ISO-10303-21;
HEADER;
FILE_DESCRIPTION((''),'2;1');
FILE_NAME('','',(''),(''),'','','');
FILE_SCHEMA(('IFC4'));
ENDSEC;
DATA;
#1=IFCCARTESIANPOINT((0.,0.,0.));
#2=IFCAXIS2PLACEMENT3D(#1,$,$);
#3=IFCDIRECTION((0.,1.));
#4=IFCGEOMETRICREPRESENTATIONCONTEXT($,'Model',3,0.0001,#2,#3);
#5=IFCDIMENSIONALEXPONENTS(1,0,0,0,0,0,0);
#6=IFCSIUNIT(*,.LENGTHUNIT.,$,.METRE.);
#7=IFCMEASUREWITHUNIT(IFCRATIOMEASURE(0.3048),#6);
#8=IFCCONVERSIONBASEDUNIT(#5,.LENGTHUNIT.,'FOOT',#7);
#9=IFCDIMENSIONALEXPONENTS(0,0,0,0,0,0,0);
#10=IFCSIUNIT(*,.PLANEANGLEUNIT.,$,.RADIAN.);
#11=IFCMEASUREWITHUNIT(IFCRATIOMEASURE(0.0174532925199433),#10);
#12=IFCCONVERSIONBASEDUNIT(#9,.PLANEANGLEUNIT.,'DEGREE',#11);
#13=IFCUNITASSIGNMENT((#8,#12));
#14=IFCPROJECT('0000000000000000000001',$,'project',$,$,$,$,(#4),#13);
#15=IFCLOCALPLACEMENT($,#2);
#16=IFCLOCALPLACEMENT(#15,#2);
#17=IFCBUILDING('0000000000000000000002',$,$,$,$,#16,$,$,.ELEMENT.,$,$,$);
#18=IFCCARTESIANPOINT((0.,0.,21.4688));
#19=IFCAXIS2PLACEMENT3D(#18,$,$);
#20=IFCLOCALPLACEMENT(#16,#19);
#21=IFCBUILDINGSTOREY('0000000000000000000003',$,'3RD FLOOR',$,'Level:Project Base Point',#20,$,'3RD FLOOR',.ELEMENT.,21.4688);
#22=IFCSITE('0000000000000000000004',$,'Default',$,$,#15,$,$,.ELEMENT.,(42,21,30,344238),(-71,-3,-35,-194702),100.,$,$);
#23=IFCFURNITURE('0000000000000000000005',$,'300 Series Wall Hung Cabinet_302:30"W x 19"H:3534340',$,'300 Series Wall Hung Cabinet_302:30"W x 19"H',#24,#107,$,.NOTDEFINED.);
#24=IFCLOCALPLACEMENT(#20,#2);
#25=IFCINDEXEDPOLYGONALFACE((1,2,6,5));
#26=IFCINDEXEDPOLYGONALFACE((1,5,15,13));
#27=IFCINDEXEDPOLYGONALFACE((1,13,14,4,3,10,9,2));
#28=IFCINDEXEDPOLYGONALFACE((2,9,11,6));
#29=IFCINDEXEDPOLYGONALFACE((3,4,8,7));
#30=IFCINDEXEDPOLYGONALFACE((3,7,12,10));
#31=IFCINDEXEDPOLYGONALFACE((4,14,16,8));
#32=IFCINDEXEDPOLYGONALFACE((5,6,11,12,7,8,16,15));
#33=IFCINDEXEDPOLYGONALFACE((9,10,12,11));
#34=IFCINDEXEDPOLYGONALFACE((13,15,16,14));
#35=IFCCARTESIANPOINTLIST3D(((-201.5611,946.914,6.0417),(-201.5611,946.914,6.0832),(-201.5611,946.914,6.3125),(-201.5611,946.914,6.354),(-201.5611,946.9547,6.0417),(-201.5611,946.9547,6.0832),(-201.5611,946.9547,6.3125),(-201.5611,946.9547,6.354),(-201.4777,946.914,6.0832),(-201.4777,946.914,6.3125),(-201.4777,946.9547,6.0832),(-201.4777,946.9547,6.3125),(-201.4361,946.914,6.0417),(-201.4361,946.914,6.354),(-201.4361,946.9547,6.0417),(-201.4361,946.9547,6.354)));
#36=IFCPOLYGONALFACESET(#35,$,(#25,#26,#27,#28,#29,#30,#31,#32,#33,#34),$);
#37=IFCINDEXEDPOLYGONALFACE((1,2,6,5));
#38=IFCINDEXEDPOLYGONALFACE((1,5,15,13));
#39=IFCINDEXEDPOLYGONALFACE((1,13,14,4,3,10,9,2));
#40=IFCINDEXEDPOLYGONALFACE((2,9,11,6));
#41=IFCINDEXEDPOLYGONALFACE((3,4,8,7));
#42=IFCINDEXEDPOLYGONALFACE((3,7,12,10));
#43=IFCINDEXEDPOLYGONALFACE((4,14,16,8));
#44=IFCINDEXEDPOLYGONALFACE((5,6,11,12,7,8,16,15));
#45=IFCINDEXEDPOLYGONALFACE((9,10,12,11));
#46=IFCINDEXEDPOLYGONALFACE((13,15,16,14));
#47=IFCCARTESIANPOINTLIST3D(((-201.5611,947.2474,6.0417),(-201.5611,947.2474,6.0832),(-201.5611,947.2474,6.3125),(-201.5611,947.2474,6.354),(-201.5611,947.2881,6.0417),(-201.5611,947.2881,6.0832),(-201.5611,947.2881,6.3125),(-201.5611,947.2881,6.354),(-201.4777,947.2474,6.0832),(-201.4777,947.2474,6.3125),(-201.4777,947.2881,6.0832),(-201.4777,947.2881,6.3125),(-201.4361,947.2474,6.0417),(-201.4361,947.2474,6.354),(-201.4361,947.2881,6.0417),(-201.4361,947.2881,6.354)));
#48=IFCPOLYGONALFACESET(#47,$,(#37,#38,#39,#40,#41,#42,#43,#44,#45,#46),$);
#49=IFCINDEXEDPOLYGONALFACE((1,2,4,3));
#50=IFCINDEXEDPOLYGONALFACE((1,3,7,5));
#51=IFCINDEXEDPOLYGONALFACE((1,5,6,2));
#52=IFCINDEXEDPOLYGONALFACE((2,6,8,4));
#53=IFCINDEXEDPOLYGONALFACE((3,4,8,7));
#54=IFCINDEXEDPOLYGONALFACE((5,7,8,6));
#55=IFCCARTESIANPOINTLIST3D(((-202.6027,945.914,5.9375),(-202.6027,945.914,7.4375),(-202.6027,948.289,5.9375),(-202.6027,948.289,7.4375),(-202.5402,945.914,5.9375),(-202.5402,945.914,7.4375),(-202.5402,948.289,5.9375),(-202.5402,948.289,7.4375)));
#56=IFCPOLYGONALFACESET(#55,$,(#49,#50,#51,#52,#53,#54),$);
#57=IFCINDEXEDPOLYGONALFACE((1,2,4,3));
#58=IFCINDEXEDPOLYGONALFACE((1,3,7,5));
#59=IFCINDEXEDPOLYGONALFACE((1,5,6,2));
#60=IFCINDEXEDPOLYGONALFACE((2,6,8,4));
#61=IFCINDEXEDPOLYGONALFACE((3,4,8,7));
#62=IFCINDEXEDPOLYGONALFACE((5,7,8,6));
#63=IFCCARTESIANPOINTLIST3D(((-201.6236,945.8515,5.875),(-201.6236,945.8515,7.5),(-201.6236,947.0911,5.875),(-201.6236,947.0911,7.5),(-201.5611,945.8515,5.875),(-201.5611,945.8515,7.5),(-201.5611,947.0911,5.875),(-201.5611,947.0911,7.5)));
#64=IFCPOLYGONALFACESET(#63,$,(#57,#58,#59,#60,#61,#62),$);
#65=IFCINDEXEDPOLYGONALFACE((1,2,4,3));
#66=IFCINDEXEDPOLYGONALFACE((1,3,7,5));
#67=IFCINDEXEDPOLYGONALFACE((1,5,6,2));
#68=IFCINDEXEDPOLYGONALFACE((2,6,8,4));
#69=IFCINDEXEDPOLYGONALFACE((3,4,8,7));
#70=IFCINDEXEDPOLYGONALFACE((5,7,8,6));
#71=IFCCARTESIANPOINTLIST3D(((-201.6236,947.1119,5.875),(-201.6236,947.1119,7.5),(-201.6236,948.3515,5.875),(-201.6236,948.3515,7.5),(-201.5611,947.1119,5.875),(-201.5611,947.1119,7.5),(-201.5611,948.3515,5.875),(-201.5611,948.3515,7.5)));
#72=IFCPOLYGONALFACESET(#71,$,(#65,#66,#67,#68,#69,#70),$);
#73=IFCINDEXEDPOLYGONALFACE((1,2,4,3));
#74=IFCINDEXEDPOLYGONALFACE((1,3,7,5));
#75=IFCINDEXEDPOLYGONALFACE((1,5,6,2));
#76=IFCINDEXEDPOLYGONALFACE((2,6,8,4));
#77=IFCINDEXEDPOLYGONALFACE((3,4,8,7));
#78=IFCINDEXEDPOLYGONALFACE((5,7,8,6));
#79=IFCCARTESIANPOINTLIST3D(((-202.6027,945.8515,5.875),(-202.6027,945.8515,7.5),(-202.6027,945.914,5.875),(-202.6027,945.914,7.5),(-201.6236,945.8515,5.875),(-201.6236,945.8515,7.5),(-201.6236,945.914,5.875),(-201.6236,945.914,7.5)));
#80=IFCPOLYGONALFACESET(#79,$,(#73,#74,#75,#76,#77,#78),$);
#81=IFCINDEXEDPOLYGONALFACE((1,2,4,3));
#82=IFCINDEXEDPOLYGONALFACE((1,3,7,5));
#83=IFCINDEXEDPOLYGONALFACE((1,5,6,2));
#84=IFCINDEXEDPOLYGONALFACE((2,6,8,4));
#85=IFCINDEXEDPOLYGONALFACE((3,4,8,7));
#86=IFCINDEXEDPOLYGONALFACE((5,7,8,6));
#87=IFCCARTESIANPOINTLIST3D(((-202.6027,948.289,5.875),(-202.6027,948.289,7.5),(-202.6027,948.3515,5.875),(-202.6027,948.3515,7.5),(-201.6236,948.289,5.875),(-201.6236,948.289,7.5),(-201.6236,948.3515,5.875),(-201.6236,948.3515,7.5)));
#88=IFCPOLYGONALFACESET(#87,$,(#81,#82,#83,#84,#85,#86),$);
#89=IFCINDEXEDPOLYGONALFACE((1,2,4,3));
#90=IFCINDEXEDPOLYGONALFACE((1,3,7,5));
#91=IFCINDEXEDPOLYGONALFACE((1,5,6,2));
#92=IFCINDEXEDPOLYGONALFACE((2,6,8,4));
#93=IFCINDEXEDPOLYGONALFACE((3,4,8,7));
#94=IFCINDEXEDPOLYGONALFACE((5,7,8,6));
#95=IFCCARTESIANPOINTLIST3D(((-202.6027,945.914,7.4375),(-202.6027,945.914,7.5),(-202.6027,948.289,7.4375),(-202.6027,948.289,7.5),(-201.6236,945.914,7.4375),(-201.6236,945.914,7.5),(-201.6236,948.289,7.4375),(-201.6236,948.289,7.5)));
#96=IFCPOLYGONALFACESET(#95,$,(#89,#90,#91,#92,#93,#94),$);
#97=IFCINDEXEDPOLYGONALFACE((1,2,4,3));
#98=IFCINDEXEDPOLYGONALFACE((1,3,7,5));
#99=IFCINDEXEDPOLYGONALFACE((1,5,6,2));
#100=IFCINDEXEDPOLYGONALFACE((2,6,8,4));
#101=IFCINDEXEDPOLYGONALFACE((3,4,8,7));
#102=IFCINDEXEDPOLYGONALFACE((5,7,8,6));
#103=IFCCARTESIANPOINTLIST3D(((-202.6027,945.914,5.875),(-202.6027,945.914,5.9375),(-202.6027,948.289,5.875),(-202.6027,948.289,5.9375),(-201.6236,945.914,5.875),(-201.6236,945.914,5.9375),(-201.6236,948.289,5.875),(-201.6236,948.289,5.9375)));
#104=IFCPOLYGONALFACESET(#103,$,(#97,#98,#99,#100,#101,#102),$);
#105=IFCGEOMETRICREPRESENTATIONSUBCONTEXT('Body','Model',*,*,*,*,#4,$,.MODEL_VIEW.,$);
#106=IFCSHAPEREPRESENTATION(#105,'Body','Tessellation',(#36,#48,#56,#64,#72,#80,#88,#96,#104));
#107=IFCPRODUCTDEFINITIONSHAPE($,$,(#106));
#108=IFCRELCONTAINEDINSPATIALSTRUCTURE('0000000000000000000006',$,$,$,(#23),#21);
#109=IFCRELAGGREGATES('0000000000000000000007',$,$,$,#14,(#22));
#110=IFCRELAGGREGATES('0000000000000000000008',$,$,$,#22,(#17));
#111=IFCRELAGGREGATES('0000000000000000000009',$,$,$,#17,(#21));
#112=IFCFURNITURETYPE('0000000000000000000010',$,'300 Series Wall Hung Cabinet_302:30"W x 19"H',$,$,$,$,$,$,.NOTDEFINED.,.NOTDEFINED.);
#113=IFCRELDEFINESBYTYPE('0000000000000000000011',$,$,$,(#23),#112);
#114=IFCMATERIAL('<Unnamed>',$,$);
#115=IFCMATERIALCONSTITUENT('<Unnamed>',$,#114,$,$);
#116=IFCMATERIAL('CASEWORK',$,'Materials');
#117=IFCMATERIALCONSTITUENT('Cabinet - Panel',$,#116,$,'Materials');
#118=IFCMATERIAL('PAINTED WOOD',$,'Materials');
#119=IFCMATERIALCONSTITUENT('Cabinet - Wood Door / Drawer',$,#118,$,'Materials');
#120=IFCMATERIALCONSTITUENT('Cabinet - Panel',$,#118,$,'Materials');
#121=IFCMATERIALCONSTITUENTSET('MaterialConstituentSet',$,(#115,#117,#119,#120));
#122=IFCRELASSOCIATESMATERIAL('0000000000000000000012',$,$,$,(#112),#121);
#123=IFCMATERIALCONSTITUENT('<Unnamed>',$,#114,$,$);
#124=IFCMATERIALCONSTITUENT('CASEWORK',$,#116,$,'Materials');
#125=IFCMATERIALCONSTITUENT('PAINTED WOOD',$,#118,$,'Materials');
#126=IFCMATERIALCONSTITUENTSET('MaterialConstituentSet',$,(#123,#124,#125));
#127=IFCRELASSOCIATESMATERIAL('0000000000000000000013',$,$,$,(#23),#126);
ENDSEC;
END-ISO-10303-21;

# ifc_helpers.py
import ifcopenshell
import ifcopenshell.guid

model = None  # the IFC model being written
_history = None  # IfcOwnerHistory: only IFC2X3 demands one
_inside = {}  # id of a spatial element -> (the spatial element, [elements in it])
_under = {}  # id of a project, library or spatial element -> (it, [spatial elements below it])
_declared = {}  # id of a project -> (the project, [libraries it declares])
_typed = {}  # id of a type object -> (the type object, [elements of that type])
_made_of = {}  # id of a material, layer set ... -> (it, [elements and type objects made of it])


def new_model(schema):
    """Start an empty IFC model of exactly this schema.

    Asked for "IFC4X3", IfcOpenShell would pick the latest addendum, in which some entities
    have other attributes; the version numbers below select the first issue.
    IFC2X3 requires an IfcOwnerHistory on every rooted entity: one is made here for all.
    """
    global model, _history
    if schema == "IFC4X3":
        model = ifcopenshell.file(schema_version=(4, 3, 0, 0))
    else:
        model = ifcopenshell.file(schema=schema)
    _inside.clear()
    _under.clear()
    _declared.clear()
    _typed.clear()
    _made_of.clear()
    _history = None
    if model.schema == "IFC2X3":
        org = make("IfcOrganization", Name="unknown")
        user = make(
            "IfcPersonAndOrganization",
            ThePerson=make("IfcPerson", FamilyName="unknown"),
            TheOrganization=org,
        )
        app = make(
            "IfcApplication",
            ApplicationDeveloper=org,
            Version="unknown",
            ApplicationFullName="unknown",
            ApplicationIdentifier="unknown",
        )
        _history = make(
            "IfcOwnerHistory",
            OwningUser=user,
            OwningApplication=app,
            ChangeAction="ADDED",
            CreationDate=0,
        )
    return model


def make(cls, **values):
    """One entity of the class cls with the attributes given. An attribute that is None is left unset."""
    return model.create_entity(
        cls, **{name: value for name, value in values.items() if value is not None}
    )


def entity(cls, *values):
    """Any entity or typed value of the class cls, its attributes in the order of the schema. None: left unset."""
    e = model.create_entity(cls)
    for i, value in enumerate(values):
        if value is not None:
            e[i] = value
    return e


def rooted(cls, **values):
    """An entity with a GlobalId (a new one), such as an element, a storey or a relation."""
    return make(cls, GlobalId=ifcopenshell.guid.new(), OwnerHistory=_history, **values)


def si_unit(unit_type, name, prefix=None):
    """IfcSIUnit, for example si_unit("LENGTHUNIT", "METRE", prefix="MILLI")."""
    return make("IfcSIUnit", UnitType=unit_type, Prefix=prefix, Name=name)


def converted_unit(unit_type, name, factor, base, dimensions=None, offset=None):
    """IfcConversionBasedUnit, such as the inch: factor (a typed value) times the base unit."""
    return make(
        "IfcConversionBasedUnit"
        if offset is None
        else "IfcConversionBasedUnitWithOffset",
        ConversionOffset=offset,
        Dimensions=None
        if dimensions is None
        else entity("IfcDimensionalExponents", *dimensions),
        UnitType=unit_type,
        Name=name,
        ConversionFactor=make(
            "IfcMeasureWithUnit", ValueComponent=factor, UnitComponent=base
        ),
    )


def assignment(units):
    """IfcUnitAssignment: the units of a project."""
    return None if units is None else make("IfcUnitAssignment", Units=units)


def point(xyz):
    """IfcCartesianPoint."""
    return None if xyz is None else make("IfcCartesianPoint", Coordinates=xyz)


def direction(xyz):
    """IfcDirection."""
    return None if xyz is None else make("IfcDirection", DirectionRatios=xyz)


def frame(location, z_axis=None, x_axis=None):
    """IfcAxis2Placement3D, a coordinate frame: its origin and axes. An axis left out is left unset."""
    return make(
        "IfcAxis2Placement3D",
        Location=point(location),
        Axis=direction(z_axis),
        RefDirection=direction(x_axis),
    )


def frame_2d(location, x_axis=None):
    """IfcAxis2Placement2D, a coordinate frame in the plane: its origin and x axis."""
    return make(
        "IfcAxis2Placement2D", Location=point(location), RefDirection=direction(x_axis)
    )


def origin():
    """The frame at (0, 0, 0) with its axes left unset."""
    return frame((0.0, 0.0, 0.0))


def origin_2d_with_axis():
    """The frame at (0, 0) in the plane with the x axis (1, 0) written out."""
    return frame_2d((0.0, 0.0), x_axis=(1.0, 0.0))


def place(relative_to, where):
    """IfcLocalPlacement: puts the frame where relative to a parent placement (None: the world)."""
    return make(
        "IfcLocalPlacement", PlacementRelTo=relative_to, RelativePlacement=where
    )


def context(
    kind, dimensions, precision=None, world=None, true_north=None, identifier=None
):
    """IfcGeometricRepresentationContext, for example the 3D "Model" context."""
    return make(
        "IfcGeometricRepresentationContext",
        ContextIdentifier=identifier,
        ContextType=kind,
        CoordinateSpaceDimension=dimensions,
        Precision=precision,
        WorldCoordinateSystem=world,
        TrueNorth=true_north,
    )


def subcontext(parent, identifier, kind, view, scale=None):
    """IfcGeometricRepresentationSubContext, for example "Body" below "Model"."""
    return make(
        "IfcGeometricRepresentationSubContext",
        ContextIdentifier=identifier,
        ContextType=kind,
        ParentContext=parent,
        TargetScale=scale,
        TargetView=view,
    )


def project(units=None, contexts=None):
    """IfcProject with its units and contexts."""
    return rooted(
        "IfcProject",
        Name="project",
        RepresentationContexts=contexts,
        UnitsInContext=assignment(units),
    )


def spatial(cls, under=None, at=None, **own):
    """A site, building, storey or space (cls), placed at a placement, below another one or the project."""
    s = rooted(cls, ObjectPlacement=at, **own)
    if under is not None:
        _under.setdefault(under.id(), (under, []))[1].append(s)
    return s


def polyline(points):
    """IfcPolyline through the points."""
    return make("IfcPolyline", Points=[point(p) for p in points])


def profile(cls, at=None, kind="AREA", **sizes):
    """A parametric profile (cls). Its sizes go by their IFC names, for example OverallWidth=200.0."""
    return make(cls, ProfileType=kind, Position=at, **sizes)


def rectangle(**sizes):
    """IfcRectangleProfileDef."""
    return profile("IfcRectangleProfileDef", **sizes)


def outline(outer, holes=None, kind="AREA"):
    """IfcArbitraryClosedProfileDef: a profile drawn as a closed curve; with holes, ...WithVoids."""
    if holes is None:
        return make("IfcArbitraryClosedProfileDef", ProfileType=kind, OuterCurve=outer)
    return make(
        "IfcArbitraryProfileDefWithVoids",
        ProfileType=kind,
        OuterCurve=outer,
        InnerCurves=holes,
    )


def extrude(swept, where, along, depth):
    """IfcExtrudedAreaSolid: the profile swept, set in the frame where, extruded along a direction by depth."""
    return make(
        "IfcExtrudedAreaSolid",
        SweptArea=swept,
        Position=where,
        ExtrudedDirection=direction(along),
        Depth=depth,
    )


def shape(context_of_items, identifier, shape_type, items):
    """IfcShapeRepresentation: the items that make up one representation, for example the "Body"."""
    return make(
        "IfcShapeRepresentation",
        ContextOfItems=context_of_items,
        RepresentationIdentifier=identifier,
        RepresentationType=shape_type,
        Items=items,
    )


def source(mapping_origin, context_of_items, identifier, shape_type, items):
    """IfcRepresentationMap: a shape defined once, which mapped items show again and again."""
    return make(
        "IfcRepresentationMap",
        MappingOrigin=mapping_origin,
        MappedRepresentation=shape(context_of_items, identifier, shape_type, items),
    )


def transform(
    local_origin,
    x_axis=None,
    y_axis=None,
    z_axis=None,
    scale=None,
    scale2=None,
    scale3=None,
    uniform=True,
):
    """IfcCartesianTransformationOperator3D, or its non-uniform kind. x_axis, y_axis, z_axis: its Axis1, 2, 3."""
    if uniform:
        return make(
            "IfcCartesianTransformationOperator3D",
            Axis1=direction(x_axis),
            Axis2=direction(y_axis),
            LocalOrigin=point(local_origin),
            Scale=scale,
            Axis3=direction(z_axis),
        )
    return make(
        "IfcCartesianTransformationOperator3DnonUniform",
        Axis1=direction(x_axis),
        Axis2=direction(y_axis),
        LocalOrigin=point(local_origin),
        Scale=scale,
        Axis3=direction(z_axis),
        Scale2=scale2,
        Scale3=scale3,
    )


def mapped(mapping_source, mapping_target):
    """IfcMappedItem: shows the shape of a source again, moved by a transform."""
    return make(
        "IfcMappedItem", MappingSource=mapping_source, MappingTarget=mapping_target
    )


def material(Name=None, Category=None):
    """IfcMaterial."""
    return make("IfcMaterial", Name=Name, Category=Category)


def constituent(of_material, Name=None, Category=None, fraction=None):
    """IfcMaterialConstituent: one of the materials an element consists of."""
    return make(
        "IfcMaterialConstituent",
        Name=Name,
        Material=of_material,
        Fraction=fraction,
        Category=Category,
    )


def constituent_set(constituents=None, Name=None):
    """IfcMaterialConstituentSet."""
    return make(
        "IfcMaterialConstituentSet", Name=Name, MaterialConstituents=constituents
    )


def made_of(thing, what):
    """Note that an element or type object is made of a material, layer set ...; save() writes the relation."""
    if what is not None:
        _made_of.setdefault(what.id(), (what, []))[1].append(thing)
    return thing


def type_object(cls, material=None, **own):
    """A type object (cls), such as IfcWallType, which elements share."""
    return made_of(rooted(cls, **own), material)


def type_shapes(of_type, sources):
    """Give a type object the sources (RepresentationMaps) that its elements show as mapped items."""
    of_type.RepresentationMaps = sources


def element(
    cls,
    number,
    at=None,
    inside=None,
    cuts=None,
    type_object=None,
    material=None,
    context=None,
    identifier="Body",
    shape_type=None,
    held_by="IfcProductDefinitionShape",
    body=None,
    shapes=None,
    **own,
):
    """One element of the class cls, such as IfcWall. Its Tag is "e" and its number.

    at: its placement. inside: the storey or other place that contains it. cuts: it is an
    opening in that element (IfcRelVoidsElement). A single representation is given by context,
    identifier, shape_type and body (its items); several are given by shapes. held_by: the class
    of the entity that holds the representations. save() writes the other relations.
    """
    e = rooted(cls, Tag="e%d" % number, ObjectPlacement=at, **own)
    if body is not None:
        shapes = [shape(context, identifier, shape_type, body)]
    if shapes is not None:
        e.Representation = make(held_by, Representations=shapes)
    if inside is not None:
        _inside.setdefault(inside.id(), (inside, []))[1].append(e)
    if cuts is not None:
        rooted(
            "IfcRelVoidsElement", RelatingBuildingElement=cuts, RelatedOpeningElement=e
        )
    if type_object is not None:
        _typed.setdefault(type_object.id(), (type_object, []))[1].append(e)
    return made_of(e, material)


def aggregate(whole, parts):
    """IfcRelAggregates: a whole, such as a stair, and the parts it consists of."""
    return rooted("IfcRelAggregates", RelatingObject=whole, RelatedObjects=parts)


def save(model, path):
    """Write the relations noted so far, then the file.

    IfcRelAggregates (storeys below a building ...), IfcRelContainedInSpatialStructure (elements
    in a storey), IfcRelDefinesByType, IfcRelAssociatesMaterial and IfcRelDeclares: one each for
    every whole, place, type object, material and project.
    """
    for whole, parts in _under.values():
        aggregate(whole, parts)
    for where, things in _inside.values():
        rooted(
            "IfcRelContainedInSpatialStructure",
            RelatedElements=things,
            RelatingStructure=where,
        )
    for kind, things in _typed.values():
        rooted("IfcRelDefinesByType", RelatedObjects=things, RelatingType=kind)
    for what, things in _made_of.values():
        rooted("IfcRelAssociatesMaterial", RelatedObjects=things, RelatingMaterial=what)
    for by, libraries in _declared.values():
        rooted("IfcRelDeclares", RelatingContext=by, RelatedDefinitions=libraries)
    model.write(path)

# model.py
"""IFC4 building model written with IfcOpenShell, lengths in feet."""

from ifc_helpers import new_model, entity, si_unit, converted_unit, direction, frame, frame_2d, origin, origin_2d_with_axis, place, context, subcontext, project, spatial, polyline, rectangle, outline, extrude, source, transform, mapped, material, constituent, constituent_set, type_object, type_shapes, element, save


model = new_model("IFC4")

# Units and contexts
model_context = context("Model", 3, precision=0.0001, world=origin(), true_north=direction((0.0, 1.0)))
body_context = subcontext(model_context, "Body", "Model", "MODEL_VIEW")
ifc_project = project(units=[converted_unit("LENGTHUNIT", "FOOT", entity("IfcRatioMeasure", 0.3048), si_unit("LENGTHUNIT", "METRE"), dimensions=[1, 0, 0, 0, 0, 0, 0]), converted_unit("PLANEANGLEUNIT", "DEGREE", entity("IfcRatioMeasure", 0.0174532925199433), si_unit("PLANEANGLEUNIT", "RADIAN"), dimensions=[0, 0, 0, 0, 0, 0, 0])], contexts=[model_context])

# Site, building, storey
site_placement = place(None, origin())
site = spatial("IfcSite", under=ifc_project, at=site_placement, Name="Default", CompositionType="ELEMENT", RefLatitude=(42, 21, 30, 344238), RefLongitude=(-71, -3, -35, -194702), RefElevation=100.0)
building_placement = place(site_placement, origin())
building = spatial("IfcBuilding", under=site, at=building_placement, CompositionType="ELEMENT")
storey_placement = place(building_placement, frame((0.0, 0.0, 21.4688)))
storey = spatial("IfcBuildingStorey", under=building, at=storey_placement, Name="3RD FLOOR", ObjectType="Level:Project Base Point", LongName="3RD FLOOR", CompositionType="ELEMENT", Elevation=21.4688)

# Furniture
ifc_material_1 = material(Name="PAINTED WOOD", Category="Materials")
ifc_material_2 = material(Name="CASEWORK", Category="Materials")
ifc_material_3 = material(Name="<Unnamed>")
ifc_constituent_1 = constituent(ifc_material_3, Name="<Unnamed>")
ifc_constituent_2 = constituent(ifc_material_2, Name="CASEWORK", Category="Materials")
ifc_constituent_3 = constituent(ifc_material_1, Name="PAINTED WOOD", Category="Materials")
ifc_constituent_set_1 = constituent_set(constituents=[ifc_constituent_1, ifc_constituent_2, ifc_constituent_3], Name="MaterialConstituentSet")
ifc_constituent_4 = constituent(ifc_material_3, Name="<Unnamed>")
ifc_constituent_5 = constituent(ifc_material_2, Name="Cabinet - Panel", Category="Materials")
ifc_constituent_6 = constituent(ifc_material_1, Name="Cabinet - Wood Door / Drawer", Category="Materials")
ifc_constituent_7 = constituent(ifc_material_1, Name="Cabinet - Panel", Category="Materials")
ifc_constituent_set_2 = constituent_set(constituents=[ifc_constituent_4, ifc_constituent_5, ifc_constituent_6, ifc_constituent_7], Name="MaterialConstituentSet")
furniture_type_1 = type_object("IfcFurnitureType", Name="300 Series Wall Hung Cabinet_302:30\"W x 19\"H", AssemblyPlace="NOTDEFINED", PredefinedType="NOTDEFINED", material=ifc_constituent_set_2)
shared_shape_1 = source(origin(), body_context, "Body", "SweptSolid", [
    extrude(outline(polyline([(0.1146, -0.0521), (0.1562, -0.0521), (0.1562, 0.0729), (-0.1562, 0.0729), (-0.1562, -0.0521), (-0.1146, -0.0521), (-0.1146, 0.0313), (0.1146, 0.0313), (0.1146, -0.0521)])), frame((1.0625, 0.0729, 0.3229), z_axis=(1.0, 0.0, 0.0), x_axis=(0.0, 0.0, 1.0)), (0.0, 0.0, 1.0), 0.0407),
    extrude(outline(polyline([(0.1146, -0.0521), (0.1562, -0.0521), (0.1562, 0.0729), (-0.1562, 0.0729), (-0.1562, -0.0521), (-0.1146, -0.0521), (-0.1146, 0.0313), (0.1146, 0.0313), (0.1146, -0.0521)])), frame((1.3958, 0.0729, 0.3229), z_axis=(1.0, 0.0, 0.0), x_axis=(0.0, 0.0, 1.0)), (0.0, 0.0, 1.0), 0.0407),
    extrude(rectangle(XDim=2.375, YDim=0.0625, at=origin_2d_with_axis()), frame((1.25, 1.1354, 0.0625), z_axis=(0.0, 0.0, 1.0), x_axis=(-1.0, 0.0, 0.0)), (0.0, 0.0, 1.0), 1.5),
    extrude(rectangle(XDim=1.2396, YDim=0.0625, at=origin_2d_with_axis()), frame((0.6198, 0.1562, 0.0), z_axis=(0.0, 0.0, 1.0), x_axis=(-1.0, 0.0, 0.0)), (0.0, 0.0, 1.0), 1.625),
    extrude(rectangle(XDim=1.2396, YDim=0.0625, at=frame_2d((0.0, 0.0), x_axis=(1.0, 0.0))), frame((1.8802, 0.1562, 0.0), z_axis=(0.0, 0.0, 1.0), x_axis=(-1.0, 0.0, 0.0)), (0.0, 0.0, 1.0), 1.625),
    extrude(rectangle(XDim=0.9792, YDim=0.0625, at=frame_2d((0.0, 0.0), x_axis=(1.0, 0.0))), frame((0.0313, 0.677, 0.0), z_axis=(0.0, 0.0, 1.0), x_axis=(0.0, -1.0, 0.0)), (0.0, 0.0, 1.0), 1.625),
    extrude(rectangle(XDim=0.9792, YDim=0.0625, at=frame_2d((0.0, 0.0), x_axis=(1.0, 0.0))), frame((2.4688, 0.677, 0.0), z_axis=(0.0, 0.0, 1.0), x_axis=(0.0, -1.0, 0.0)), (0.0, 0.0, 1.0), 1.625),
    extrude(rectangle(XDim=0.9792, YDim=2.375, at=frame_2d((0.0, 0.0), x_axis=(1.0, 0.0))), frame((1.25, 0.677, 1.5625), z_axis=(0.0, 0.0, 1.0), x_axis=(0.0, 1.0, 0.0)), (0.0, 0.0, 1.0), 0.0625),
    extrude(rectangle(XDim=0.9792, YDim=2.375, at=frame_2d((0.0, 0.0), x_axis=(1.0, 0.0))), frame((1.25, 0.677, 0.0), z_axis=(0.0, 0.0, 1.0), x_axis=(0.0, 1.0, 0.0)), (0.0, 0.0, 1.0), 0.0625),
])
type_shapes(furniture_type_1, [shared_shape_1])
furniture_1_placement = place(storey_placement, frame((-201.4361, 945.8515, 5.875), z_axis=(0.0, 0.0, 1.0), x_axis=(0.0, 1.0, 0.0)))
element("IfcFurniture", 1, at=furniture_1_placement, inside=storey, type_object=furniture_type_1, material=ifc_constituent_set_1, Name="300 Series Wall Hung Cabinet_302:30\"W x 19\"H:3534340", ObjectType="300 Series Wall Hung Cabinet_302:30\"W x 19\"H", PredefinedType="NOTDEFINED", context=body_context, shape_type="MappedRepresentation", body=[
    mapped(shared_shape_1, transform((0.0, 0.0, 0.0), scale=1.0)),
])

save(model, "model.ifc")
